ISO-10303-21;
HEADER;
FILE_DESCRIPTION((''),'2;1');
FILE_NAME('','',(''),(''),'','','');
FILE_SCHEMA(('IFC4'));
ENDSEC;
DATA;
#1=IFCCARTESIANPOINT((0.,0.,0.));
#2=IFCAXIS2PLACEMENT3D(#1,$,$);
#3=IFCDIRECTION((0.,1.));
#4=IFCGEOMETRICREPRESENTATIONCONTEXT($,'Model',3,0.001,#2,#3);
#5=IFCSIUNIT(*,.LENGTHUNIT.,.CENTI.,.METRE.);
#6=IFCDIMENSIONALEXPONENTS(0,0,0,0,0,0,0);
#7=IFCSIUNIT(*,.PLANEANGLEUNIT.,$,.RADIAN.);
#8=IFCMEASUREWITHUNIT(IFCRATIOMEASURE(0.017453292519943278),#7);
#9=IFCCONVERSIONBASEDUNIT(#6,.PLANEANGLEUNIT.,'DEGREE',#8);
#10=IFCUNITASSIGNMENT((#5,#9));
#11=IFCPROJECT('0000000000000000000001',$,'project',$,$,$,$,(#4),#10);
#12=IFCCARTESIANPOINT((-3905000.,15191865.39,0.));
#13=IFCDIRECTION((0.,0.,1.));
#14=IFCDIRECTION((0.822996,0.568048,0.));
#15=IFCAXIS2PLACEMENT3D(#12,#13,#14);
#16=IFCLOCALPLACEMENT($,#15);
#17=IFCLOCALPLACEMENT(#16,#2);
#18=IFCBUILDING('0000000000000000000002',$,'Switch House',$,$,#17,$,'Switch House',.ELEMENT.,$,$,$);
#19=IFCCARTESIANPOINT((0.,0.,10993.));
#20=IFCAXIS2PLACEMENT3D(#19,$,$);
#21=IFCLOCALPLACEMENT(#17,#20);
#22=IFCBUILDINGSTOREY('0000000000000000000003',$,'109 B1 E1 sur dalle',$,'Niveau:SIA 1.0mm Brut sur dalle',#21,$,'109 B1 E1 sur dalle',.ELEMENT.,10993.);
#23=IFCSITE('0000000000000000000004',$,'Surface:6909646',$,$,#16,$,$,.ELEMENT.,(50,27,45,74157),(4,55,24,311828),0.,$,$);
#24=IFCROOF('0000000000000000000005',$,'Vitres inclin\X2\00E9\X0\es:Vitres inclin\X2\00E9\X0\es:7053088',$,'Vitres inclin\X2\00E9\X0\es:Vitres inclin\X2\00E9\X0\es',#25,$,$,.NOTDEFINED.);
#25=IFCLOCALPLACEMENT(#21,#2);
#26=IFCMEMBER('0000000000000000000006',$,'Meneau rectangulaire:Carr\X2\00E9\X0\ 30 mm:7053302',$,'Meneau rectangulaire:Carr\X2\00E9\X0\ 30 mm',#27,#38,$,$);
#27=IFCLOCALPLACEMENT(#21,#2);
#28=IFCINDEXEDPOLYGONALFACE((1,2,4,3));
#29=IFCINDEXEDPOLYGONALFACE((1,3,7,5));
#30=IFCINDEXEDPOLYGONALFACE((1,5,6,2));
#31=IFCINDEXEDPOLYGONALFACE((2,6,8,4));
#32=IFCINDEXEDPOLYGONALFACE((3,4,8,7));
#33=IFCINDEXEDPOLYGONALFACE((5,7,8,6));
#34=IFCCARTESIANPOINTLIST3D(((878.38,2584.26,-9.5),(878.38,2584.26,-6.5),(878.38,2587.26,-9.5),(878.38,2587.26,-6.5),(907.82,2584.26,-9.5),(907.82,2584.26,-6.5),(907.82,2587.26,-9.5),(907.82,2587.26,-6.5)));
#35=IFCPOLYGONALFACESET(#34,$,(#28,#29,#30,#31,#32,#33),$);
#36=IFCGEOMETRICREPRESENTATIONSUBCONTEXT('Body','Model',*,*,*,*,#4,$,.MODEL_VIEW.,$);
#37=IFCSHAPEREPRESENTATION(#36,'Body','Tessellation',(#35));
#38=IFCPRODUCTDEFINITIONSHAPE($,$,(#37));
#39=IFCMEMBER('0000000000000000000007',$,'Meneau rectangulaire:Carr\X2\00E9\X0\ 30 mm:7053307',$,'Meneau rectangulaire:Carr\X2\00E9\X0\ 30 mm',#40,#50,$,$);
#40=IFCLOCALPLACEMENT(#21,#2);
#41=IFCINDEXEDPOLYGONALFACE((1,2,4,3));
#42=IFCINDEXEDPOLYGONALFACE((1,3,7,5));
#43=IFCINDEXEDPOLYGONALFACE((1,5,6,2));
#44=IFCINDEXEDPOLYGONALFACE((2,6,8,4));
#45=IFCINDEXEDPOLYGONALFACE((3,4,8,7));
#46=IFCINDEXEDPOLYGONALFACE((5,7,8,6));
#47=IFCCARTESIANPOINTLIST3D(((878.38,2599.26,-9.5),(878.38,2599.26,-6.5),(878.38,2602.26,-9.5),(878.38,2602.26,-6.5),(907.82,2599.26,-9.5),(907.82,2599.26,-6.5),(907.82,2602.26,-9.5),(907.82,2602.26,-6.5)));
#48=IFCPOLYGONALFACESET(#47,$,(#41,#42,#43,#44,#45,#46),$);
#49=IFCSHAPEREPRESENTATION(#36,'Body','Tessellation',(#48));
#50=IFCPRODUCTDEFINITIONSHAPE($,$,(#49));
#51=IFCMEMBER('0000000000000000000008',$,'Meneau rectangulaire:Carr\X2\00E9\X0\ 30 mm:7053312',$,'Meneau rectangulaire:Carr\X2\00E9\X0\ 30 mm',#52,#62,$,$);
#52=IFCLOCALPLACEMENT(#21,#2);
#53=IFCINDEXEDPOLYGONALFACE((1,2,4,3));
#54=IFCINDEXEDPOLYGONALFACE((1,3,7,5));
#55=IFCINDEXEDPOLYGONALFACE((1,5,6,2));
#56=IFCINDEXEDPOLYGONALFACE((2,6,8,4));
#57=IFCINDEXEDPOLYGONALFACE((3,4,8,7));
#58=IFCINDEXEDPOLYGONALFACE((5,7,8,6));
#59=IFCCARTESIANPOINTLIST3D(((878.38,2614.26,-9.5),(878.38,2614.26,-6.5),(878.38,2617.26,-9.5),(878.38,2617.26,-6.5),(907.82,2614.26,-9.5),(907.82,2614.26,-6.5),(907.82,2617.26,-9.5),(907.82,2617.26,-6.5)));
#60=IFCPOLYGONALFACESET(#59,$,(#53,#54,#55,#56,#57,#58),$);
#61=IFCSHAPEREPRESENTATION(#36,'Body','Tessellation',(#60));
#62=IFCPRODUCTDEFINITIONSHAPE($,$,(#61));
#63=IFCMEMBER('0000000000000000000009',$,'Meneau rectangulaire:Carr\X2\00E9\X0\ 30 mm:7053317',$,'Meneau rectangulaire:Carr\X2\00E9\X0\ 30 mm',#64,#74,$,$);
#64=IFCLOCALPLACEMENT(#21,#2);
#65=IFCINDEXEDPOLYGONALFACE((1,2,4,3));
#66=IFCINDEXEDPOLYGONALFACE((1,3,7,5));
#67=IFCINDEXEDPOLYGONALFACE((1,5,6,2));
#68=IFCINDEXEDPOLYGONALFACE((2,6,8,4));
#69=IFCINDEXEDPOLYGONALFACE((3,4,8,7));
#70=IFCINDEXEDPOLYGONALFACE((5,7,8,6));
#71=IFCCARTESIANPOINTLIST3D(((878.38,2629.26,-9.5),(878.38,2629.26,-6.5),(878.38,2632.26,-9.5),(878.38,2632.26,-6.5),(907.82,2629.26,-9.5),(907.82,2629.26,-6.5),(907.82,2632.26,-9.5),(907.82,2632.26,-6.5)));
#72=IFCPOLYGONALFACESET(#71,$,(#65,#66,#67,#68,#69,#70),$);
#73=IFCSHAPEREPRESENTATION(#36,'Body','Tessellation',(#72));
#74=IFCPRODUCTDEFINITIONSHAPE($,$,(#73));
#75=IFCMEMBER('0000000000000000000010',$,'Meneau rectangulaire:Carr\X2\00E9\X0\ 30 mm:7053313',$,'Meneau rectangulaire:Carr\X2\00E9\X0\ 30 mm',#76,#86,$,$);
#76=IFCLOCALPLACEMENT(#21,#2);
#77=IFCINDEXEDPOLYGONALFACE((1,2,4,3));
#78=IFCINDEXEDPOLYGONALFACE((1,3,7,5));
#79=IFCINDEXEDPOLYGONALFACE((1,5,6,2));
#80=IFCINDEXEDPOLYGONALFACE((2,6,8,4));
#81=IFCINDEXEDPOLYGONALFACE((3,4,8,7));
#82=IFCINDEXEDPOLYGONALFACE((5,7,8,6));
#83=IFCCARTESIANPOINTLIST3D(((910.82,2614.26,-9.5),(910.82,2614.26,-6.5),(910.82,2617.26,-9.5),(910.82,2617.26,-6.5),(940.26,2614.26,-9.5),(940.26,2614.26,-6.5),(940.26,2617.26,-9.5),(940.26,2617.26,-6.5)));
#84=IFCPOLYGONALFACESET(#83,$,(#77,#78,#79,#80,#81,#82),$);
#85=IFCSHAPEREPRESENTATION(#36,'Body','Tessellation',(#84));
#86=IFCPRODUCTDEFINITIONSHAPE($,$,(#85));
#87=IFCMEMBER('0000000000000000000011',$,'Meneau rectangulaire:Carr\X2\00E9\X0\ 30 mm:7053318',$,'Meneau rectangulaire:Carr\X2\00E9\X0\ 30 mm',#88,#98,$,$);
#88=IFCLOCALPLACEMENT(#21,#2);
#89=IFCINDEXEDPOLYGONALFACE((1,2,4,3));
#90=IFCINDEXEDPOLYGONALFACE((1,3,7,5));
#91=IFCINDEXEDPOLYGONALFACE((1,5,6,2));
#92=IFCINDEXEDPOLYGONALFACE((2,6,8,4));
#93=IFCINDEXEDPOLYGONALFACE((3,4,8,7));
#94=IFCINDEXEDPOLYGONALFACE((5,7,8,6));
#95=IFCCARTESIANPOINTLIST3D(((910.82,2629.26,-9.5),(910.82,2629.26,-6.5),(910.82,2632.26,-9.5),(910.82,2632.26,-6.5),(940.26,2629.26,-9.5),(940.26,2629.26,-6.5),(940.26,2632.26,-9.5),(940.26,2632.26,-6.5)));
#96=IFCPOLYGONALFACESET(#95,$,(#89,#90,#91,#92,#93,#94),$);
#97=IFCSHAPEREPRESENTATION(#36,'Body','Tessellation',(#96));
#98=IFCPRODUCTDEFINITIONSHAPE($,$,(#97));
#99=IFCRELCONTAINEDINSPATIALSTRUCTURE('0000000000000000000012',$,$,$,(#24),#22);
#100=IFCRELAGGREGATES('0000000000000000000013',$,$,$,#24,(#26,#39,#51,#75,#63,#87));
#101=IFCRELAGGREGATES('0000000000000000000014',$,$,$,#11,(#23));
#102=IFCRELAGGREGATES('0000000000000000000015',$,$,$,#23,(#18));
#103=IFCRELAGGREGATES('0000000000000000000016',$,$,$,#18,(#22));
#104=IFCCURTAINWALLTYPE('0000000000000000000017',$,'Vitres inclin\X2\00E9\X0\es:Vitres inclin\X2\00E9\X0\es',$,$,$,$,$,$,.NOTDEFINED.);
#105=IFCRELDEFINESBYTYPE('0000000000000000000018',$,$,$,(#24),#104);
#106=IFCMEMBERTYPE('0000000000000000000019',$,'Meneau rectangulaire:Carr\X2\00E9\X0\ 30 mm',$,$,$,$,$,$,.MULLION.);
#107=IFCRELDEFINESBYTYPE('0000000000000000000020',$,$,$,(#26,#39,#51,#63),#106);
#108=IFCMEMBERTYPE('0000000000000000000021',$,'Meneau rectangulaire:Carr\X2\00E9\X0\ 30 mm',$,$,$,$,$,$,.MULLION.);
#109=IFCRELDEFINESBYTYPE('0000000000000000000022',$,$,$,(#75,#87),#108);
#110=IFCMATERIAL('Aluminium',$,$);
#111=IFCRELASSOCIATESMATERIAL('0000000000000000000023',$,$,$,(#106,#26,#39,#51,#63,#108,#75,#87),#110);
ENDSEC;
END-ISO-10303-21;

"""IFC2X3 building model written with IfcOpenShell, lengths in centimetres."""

from ifc_helpers import new_model, entity, si_unit, converted_unit, direction, frame, origin, origin_2d_with_axis, place, context, subcontext, project, spatial, rectangle, extrude, source, transform, mapped, material, type_object, type_shapes, element, aggregate, save


model = new_model("IFC2X3")

# Units and contexts
model_context = context("Model", 3, precision=0.001, world=origin(), true_north=direction((0.0, 1.0)))
body_context = subcontext(model_context, "Body", "Model", "MODEL_VIEW")
ifc_project = project(units=[si_unit("LENGTHUNIT", "METRE", prefix="CENTI"), converted_unit("PLANEANGLEUNIT", "DEGREE", entity("IfcRatioMeasure", 0.017453292519943278), si_unit("PLANEANGLEUNIT", "RADIAN"), dimensions=[0, 0, 0, 0, 0, 0, 0])], contexts=[model_context])

# Site, building, storey
site_placement = place(None, frame((-3905000.0, 15191865.39, 0.0), z_axis=(0.0, 0.0, 1.0), x_axis=(0.822996, 0.568048, 0.0)))
site = spatial("IfcSite", under=ifc_project, at=site_placement, Name="Surface:6909646", CompositionType="ELEMENT", RefLatitude=(50, 27, 45, 74157), RefLongitude=(4, 55, 24, 311828), RefElevation=0.0)
building_placement = place(site_placement, origin())
building = spatial("IfcBuilding", under=site, at=building_placement, Name="Switch House", LongName="Switch House", CompositionType="ELEMENT")
storey_placement = place(building_placement, frame((0.0, 0.0, 10993.0)))
storey = spatial("IfcBuildingStorey", under=building, at=storey_placement, Name="109 B1 E1 sur dalle", ObjectType="Niveau:SIA 1.0mm Brut sur dalle", LongName="109 B1 E1 sur dalle", CompositionType="ELEMENT", Elevation=10993.0)

# Roof
curtain_wall_type = type_object("IfcCurtainWallType", Name="Vitres inclinées:Vitres inclinées", PredefinedType="NOTDEFINED")
ifc_material = material(Name="Aluminium")
roof_1_placement = place(storey_placement, frame((0.0, 0.0, -10993.0)))
roof_1 = element("IfcRoof", 1, at=roof_1_placement, inside=storey, type_object=curtain_wall_type, Name="Vitres inclinées:Vitres inclinées:7053088", ObjectType="Vitres inclinées:Vitres inclinées", ShapeType="NOTDEFINED")

# Members
member_type_1 = type_object("IfcMemberType", Name="Meneau rectangulaire:Carré 30 mm", PredefinedType="MULLION", material=ifc_material)
shared_shape_1 = source(origin(), body_context, "Body", "SweptSolid", [
    extrude(rectangle(XDim=3.0, YDim=3.0, at=origin_2d_with_axis()), frame((0.0, 0.0, -29.44), z_axis=(0.0, 0.0, 1.0), x_axis=(0.0, -1.0, 0.0)), (0.0, 0.0, 1.0), 29.44),
])
type_shapes(member_type_1, [shared_shape_1])
member_1_placement = place(roof_1_placement, frame((878.38, 2585.76, 10985.0), z_axis=(-1.0, 0.0, 0.0), x_axis=(0.0, 1.0, 0.0)))
member_1 = element("IfcMember", 2, at=member_1_placement, type_object=member_type_1, material=ifc_material, Name="Meneau rectangulaire:Carré 30 mm:7053302", ObjectType="Meneau rectangulaire:Carré 30 mm", context=body_context, shape_type="MappedRepresentation", body=[
    mapped(shared_shape_1, transform((0.0, 0.0, 0.0), scale=1.0)),
])
member_2_placement = place(roof_1_placement, frame((878.38, 2600.76, 10985.0), z_axis=(-1.0, 0.0, 0.0), x_axis=(0.0, 1.0, 0.0)))
member_2 = element("IfcMember", 3, at=member_2_placement, type_object=member_type_1, material=ifc_material, Name="Meneau rectangulaire:Carré 30 mm:7053307", ObjectType="Meneau rectangulaire:Carré 30 mm", context=body_context, shape_type="MappedRepresentation", body=[
    mapped(shared_shape_1, transform((0.0, 0.0, 0.0), scale=1.0)),
])
member_3_placement = place(roof_1_placement, frame((878.38, 2615.76, 10985.0), z_axis=(-1.0, 0.0, 0.0), x_axis=(0.0, 1.0, 0.0)))
member_3 = element("IfcMember", 4, at=member_3_placement, type_object=member_type_1, material=ifc_material, Name="Meneau rectangulaire:Carré 30 mm:7053312", ObjectType="Meneau rectangulaire:Carré 30 mm", context=body_context, shape_type="MappedRepresentation", body=[
    mapped(shared_shape_1, transform((0.0, 0.0, 0.0), scale=1.0)),
])
member_4_placement = place(roof_1_placement, frame((878.38, 2630.76, 10985.0), z_axis=(-1.0, 0.0, 0.0), x_axis=(0.0, 1.0, 0.0)))
member_4 = element("IfcMember", 5, at=member_4_placement, type_object=member_type_1, material=ifc_material, Name="Meneau rectangulaire:Carré 30 mm:7053317", ObjectType="Meneau rectangulaire:Carré 30 mm", context=body_context, shape_type="MappedRepresentation", body=[
    mapped(shared_shape_1, transform((0.0, 0.0, 0.0), scale=1.0)),
])
member_type_2 = type_object("IfcMemberType", Name="Meneau rectangulaire:Carré 30 mm", PredefinedType="MULLION", material=ifc_material)
shared_shape_2 = source(origin(), body_context, "Body", "SweptSolid", [
    extrude(rectangle(XDim=3.0, YDim=3.0, at=origin_2d_with_axis()), frame((0.0, 0.0, -29.44), z_axis=(0.0, 0.0, 1.0), x_axis=(0.0, -1.0, 0.0)), (0.0, 0.0, 1.0), 29.44),
])
type_shapes(member_type_2, [shared_shape_2])
member_5_placement = place(roof_1_placement, frame((910.82, 2615.76, 10985.0), z_axis=(-1.0, 0.0, 0.0), x_axis=(0.0, 1.0, 0.0)))
member_5 = element("IfcMember", 6, at=member_5_placement, type_object=member_type_2, material=ifc_material, Name="Meneau rectangulaire:Carré 30 mm:7053313", ObjectType="Meneau rectangulaire:Carré 30 mm", context=body_context, shape_type="MappedRepresentation", body=[
    mapped(shared_shape_2, transform((0.0, 0.0, 0.0), scale=1.0)),
])
member_6_placement = place(roof_1_placement, frame((910.82, 2630.76, 10985.0), z_axis=(-1.0, 0.0, 0.0), x_axis=(0.0, 1.0, 0.0)))
member_6 = element("IfcMember", 7, at=member_6_placement, type_object=member_type_2, material=ifc_material, Name="Meneau rectangulaire:Carré 30 mm:7053318", ObjectType="Meneau rectangulaire:Carré 30 mm", context=body_context, shape_type="MappedRepresentation", body=[
    mapped(shared_shape_2, transform((0.0, 0.0, 0.0), scale=1.0)),
])
aggregate(roof_1, [member_1, member_2, member_3, member_5, member_4, member_6])

save(model, "model.ifc")
